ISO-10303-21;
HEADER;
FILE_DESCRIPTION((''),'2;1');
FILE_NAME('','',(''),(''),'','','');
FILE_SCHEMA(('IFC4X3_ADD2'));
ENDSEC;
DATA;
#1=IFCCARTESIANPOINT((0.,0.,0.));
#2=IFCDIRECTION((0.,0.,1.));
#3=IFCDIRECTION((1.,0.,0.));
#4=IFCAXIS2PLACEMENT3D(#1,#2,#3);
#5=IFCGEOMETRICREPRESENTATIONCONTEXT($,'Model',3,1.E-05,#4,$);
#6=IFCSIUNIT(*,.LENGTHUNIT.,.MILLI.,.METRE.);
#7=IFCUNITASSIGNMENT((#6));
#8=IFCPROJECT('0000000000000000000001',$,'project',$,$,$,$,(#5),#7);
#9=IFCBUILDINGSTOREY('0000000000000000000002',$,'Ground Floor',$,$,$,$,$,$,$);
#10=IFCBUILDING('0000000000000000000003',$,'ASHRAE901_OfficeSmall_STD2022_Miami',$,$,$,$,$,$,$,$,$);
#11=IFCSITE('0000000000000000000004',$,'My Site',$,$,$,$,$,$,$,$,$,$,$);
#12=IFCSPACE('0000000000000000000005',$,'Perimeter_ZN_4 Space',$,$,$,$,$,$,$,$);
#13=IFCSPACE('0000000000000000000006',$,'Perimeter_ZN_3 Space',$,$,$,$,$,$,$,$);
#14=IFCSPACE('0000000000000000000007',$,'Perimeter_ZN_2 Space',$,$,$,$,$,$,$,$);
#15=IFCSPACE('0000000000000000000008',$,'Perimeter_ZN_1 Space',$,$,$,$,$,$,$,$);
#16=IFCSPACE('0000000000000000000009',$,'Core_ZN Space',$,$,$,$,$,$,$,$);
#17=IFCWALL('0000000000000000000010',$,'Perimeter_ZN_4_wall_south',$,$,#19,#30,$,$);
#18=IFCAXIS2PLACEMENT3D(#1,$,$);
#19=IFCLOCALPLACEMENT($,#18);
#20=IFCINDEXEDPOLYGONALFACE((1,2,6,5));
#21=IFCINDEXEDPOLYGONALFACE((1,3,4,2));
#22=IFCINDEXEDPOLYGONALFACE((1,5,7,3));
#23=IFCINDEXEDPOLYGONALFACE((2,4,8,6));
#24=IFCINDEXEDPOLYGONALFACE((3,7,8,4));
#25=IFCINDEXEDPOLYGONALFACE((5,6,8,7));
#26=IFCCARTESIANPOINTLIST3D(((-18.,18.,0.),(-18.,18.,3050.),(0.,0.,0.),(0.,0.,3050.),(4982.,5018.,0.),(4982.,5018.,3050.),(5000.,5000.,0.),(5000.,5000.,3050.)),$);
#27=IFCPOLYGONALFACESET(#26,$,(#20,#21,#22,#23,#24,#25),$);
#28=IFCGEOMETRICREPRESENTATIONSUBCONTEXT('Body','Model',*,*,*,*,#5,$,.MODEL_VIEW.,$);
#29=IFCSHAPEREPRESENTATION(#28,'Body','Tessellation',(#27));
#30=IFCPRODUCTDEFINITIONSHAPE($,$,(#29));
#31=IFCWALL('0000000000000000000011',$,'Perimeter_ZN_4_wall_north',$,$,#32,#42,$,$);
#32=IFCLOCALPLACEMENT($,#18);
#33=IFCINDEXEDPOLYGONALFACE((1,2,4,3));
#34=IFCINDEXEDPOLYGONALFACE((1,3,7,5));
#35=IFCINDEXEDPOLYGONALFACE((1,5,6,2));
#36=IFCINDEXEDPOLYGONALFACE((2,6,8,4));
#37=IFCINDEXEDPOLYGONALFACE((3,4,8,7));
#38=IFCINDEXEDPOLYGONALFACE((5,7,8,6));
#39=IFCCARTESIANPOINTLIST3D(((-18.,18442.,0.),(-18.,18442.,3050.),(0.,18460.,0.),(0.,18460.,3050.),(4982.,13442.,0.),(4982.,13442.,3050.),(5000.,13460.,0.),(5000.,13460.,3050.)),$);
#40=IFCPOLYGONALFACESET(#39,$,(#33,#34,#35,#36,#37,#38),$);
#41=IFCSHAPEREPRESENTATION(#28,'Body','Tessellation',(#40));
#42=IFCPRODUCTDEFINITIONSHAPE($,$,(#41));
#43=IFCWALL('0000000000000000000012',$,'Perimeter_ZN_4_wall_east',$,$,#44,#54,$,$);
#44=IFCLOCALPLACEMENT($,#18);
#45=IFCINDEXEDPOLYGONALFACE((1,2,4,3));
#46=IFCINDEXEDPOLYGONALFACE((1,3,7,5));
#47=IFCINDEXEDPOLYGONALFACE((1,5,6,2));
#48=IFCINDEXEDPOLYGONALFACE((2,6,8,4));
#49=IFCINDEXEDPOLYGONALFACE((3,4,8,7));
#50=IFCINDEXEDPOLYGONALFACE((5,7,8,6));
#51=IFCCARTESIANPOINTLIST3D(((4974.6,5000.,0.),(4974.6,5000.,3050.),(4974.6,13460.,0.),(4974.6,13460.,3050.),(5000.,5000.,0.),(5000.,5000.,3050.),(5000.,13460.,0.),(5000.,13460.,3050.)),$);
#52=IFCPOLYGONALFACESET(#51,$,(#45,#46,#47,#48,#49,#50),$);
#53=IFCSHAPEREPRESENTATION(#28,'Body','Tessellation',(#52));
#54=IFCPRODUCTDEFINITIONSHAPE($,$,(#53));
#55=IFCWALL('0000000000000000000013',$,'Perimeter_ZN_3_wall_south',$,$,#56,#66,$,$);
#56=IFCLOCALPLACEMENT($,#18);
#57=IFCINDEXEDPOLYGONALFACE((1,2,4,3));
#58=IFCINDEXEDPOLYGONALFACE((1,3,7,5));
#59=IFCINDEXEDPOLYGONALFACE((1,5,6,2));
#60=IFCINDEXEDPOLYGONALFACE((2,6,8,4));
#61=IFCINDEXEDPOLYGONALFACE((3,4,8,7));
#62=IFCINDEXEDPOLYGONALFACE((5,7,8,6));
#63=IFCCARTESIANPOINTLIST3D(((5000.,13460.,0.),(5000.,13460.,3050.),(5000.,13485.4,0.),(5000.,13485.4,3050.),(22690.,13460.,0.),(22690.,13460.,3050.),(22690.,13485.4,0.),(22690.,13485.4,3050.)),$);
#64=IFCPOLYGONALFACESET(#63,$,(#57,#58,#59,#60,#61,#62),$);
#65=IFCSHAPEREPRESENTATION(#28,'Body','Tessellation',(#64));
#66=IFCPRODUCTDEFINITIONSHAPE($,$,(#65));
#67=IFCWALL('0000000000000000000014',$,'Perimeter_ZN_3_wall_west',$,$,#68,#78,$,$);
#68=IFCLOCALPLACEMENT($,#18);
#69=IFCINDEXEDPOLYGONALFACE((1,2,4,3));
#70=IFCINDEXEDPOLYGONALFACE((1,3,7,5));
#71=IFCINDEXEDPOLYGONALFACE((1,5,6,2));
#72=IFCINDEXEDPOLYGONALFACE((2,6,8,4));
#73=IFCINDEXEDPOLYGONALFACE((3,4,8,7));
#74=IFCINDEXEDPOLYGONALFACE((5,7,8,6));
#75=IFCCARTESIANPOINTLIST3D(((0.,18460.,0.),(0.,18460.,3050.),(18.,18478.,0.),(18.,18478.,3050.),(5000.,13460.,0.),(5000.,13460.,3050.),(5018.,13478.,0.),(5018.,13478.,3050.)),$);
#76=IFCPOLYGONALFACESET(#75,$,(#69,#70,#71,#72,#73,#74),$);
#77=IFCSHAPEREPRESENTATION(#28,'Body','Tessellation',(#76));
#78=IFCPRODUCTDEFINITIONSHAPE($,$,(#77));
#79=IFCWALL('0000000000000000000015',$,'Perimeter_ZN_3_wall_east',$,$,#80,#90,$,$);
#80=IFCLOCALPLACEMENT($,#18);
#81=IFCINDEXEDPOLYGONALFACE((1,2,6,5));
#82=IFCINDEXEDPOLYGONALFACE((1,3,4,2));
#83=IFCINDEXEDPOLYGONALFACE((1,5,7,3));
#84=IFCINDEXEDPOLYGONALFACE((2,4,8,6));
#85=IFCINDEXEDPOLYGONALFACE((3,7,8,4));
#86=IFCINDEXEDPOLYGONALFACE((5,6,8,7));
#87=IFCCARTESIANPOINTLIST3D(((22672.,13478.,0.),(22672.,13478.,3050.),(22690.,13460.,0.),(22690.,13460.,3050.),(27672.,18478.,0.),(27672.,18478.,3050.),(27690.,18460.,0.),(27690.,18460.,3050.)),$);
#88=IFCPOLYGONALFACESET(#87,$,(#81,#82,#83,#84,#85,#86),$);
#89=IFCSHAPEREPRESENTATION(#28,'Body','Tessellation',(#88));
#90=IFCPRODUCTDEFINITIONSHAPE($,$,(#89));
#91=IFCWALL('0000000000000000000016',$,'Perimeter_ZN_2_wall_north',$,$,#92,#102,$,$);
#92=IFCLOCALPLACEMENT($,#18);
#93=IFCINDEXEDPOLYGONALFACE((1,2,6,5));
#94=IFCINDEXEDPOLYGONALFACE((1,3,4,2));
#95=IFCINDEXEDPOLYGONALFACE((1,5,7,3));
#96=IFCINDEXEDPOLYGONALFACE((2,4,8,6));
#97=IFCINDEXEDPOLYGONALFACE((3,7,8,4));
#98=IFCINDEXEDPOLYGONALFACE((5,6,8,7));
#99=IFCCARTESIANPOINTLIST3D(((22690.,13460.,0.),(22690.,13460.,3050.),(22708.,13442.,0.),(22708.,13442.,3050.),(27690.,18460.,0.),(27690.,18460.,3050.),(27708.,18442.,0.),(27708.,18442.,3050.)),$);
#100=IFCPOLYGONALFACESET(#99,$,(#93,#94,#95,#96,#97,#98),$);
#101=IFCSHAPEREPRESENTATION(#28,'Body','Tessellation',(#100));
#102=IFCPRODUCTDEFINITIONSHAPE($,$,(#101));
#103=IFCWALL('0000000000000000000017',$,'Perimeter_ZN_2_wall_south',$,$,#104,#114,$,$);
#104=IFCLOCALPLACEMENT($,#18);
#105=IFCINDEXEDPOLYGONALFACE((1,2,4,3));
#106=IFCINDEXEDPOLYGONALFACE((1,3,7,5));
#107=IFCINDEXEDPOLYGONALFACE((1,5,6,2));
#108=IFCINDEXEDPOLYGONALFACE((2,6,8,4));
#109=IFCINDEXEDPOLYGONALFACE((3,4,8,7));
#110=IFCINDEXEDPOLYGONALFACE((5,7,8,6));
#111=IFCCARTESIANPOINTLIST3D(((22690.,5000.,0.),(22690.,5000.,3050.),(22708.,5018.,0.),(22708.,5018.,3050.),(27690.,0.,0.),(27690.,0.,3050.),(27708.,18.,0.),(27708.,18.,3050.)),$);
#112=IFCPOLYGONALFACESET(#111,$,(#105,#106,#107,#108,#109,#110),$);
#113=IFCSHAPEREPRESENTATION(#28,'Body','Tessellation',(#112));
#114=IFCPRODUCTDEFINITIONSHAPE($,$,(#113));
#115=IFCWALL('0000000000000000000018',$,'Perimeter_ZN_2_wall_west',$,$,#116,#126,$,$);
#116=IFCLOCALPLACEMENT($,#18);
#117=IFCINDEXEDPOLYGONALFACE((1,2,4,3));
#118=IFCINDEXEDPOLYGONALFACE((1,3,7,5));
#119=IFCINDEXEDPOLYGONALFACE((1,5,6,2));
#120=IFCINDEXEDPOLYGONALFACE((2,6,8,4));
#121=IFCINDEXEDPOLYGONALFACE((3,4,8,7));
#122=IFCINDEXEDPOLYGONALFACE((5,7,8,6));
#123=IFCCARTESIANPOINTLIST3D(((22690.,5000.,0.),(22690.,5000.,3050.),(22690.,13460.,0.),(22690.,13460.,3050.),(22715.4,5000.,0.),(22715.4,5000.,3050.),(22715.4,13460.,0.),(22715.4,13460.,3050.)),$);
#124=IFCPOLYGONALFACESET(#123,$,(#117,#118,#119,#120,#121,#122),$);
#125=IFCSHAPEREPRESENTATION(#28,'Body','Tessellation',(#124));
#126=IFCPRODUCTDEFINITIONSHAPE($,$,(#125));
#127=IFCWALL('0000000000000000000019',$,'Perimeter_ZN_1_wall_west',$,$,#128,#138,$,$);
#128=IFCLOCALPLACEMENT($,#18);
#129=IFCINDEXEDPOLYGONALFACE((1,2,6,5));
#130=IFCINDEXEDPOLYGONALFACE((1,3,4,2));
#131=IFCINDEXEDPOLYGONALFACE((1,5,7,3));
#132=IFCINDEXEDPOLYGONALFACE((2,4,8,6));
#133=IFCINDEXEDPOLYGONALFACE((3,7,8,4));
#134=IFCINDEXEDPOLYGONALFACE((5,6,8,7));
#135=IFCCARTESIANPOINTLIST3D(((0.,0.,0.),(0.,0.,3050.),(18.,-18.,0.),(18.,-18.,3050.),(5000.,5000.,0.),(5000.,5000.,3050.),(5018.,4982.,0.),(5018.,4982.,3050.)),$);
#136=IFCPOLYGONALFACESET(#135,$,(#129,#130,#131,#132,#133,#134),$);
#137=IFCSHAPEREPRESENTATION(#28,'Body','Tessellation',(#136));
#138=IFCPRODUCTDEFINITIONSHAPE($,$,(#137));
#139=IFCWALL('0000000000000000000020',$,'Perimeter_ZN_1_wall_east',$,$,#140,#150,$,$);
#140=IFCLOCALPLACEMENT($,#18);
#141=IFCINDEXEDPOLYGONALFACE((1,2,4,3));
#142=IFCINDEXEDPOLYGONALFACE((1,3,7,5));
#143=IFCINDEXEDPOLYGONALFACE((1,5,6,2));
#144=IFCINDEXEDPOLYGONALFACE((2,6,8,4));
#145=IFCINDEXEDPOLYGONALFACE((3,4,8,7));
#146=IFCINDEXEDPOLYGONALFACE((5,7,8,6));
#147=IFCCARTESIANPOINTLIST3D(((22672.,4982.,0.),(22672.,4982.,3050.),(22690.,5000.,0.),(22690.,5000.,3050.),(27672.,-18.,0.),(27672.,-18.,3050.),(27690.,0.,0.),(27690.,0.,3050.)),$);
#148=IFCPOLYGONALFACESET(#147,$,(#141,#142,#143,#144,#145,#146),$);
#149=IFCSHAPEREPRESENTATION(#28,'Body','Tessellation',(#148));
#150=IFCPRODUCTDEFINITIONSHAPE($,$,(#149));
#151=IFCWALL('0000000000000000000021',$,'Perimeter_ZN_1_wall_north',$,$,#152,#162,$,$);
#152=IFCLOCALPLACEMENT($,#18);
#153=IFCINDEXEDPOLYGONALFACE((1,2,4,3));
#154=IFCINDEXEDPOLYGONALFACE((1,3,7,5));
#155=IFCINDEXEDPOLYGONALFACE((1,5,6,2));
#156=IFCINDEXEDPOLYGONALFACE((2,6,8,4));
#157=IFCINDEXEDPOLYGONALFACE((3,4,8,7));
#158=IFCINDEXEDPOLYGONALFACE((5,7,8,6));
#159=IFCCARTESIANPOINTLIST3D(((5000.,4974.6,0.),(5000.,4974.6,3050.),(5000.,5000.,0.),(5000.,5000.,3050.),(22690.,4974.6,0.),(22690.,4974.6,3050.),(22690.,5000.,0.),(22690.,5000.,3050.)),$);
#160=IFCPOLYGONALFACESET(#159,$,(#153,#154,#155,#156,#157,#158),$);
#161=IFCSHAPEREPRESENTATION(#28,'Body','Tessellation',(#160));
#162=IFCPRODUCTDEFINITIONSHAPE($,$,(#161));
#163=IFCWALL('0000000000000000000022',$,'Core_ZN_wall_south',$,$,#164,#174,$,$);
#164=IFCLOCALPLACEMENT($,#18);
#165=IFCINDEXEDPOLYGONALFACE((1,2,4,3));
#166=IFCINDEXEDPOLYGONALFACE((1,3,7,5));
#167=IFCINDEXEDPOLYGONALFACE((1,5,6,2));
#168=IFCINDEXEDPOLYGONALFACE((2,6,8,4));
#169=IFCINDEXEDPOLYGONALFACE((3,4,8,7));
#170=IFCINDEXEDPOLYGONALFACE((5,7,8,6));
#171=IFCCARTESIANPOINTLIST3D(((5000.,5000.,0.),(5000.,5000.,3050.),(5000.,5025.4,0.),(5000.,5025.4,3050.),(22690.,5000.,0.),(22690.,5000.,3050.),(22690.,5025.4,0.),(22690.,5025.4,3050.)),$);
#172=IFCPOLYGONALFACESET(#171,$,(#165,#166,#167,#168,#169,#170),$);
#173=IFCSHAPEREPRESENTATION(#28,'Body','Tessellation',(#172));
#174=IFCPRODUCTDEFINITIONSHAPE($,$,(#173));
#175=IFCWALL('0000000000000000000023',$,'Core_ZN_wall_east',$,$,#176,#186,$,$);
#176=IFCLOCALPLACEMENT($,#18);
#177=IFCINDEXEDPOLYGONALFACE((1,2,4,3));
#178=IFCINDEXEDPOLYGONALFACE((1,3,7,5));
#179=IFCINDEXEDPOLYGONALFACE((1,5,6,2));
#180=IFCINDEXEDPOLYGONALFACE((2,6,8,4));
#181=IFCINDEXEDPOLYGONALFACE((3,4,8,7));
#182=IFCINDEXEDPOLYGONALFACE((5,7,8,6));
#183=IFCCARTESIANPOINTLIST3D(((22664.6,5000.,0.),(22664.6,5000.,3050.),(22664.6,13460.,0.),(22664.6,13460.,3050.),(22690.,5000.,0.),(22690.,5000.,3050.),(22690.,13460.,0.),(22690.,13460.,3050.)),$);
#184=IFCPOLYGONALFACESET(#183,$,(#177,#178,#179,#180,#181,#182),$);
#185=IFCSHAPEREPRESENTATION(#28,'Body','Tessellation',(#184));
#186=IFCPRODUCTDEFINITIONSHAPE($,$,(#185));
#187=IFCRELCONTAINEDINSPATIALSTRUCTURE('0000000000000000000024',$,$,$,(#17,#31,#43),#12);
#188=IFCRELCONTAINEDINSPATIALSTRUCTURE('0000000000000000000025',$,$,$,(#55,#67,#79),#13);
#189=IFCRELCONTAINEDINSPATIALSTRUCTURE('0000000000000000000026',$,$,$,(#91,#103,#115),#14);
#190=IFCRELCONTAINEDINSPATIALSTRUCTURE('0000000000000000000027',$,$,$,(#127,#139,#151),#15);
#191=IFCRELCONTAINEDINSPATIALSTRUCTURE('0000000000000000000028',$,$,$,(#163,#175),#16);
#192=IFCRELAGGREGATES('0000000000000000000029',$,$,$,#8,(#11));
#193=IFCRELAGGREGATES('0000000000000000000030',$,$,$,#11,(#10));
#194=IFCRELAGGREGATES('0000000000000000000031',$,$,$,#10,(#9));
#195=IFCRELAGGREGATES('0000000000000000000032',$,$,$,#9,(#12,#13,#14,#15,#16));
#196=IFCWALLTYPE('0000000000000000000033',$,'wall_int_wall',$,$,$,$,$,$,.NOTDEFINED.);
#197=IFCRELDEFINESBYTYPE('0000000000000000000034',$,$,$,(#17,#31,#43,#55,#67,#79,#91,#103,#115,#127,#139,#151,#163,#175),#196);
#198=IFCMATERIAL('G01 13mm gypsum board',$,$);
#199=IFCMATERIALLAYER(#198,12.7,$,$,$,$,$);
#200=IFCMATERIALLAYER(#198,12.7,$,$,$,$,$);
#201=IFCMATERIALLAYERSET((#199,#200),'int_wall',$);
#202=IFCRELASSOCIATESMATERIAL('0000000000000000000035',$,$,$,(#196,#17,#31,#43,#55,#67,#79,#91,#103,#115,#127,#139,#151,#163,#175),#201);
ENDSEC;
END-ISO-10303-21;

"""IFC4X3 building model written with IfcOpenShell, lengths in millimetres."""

from ifc_helpers import new_model, si_unit, frame, origin_with_axes, place, context, subcontext, project, spatial, indexed_curve, outline, extrude, material, layer, layer_set, layer_usage, type_object, element, save


model = new_model("IFC4X3")

# Units and contexts
model_context = context("Model", 3, precision=1e-05, world=origin_with_axes())
body_context = subcontext(model_context, "Body", "Model", "MODEL_VIEW")
ifc_project = project(units=[si_unit("LENGTHUNIT", "METRE", prefix="MILLI")], contexts=[model_context])

# Site, building, storey, space
site = spatial("IfcSite", under=ifc_project, Name="My Site")
building = spatial("IfcBuilding", under=site, Name="ASHRAE901_OfficeSmall_STD2022_Miami")
storey = spatial("IfcBuildingStorey", under=building, Name="Ground Floor")
space_1 = spatial("IfcSpace", under=storey, Name="Perimeter_ZN_4 Space")

# Walls
ifc_material = material(Name="G01 13mm gypsum board")
ifc_layer_1 = layer(ifc_material, 12.7)
ifc_layer_2 = layer(ifc_material, 12.7)
ifc_layer_set = layer_set([ifc_layer_1, ifc_layer_2], Name="int_wall")
ifc_layer_usage_1 = layer_usage(ifc_layer_set, "AXIS2", "POSITIVE", 0.0)
wall_type = type_object("IfcWallType", Name="wall_int_wall", PredefinedType="NOTDEFINED", material=ifc_layer_set)
wall_1_placement = place(None, frame((0.0, 0.0, 0.0), z_axis=(0.0, 0.0, 1.0), x_axis=(0.707107, 0.707107, 0.0)))
element("IfcWall", 1, at=wall_1_placement, inside=space_1, type_object=wall_type, material=ifc_layer_usage_1, Name="Perimeter_ZN_4_wall_south", context=body_context, shape_type="SweptSolid", body=[
    extrude(outline(indexed_curve([(0.0, 0.0), (0.0, 25.4), (7071.1, 25.4), (7071.1, 0.0), (0.0, 0.0)], self_intersect=False)), origin_with_axes(), (0.0, 0.0, 1.0), 3050.0),
])
ifc_layer_usage_2 = layer_usage(ifc_layer_set, "AXIS2", "POSITIVE", 0.0)
wall_2_placement = place(None, frame((5000.0, 13460.0, 0.0), z_axis=(0.0, 0.0, 1.0), x_axis=(-0.707107, 0.707107, 0.0)))
element("IfcWall", 2, at=wall_2_placement, inside=space_1, type_object=wall_type, material=ifc_layer_usage_2, Name="Perimeter_ZN_4_wall_north", context=body_context, shape_type="SweptSolid", body=[
    extrude(outline(indexed_curve([(0.0, 0.0), (0.0, 25.4), (7071.1, 25.4), (7071.1, 0.0), (0.0, 0.0)], self_intersect=False)), origin_with_axes(), (0.0, 0.0, 1.0), 3050.0),
])
ifc_layer_usage_3 = layer_usage(ifc_layer_set, "AXIS2", "POSITIVE", 0.0)
wall_3_placement = place(None, frame((5000.0, 5000.0, 0.0), z_axis=(0.0, 0.0, 1.0), x_axis=(0.0, 1.0, 0.0)))
element("IfcWall", 3, at=wall_3_placement, inside=space_1, type_object=wall_type, material=ifc_layer_usage_3, Name="Perimeter_ZN_4_wall_east", context=body_context, shape_type="SweptSolid", body=[
    extrude(outline(indexed_curve([(0.0, 0.0), (0.0, 25.4), (8460.0, 25.4), (8460.0, 0.0), (0.0, 0.0)], self_intersect=False)), origin_with_axes(), (0.0, 0.0, 1.0), 3050.0),
])

# Shared definitions
space_2 = spatial("IfcSpace", under=storey, Name="Perimeter_ZN_3 Space")

# Walls
ifc_layer_usage_4 = layer_usage(ifc_layer_set, "AXIS2", "POSITIVE", 0.0)
wall_4_placement = place(None, frame((5000.0, 13460.0, 0.0), z_axis=(0.0, 0.0, 1.0), x_axis=(1.0, 0.0, 0.0)))
element("IfcWall", 4, at=wall_4_placement, inside=space_2, type_object=wall_type, material=ifc_layer_usage_4, Name="Perimeter_ZN_3_wall_south", context=body_context, shape_type="SweptSolid", body=[
    extrude(outline(indexed_curve([(0.0, 0.0), (0.0, 25.4), (17690.0, 25.4), (17690.0, 0.0), (0.0, 0.0)], self_intersect=False)), origin_with_axes(), (0.0, 0.0, 1.0), 3050.0),
])
ifc_layer_usage_5 = layer_usage(ifc_layer_set, "AXIS2", "POSITIVE", 0.0)
wall_5_placement = place(None, frame((0.0, 18460.0, 0.0), z_axis=(0.0, 0.0, 1.0), x_axis=(0.707107, -0.707107, 0.0)))
element("IfcWall", 5, at=wall_5_placement, inside=space_2, type_object=wall_type, material=ifc_layer_usage_5, Name="Perimeter_ZN_3_wall_west", context=body_context, shape_type="SweptSolid", body=[
    extrude(outline(indexed_curve([(0.0, 0.0), (0.0, 25.4), (7071.1, 25.4), (7071.1, 0.0), (0.0, 0.0)], self_intersect=False)), origin_with_axes(), (0.0, 0.0, 1.0), 3050.0),
])
ifc_layer_usage_6 = layer_usage(ifc_layer_set, "AXIS2", "POSITIVE", 0.0)
wall_6_placement = place(None, frame((22690.0, 13460.0, 0.0), z_axis=(0.0, 0.0, 1.0), x_axis=(0.707107, 0.707107, 0.0)))
element("IfcWall", 6, at=wall_6_placement, inside=space_2, type_object=wall_type, material=ifc_layer_usage_6, Name="Perimeter_ZN_3_wall_east", context=body_context, shape_type="SweptSolid", body=[
    extrude(outline(indexed_curve([(0.0, 0.0), (0.0, 25.4), (7071.1, 25.4), (7071.1, 0.0), (0.0, 0.0)], self_intersect=False)), origin_with_axes(), (0.0, 0.0, 1.0), 3050.0),
])

# Shared definitions
space_3 = spatial("IfcSpace", under=storey, Name="Perimeter_ZN_2 Space")

# Walls
ifc_layer_usage_7 = layer_usage(ifc_layer_set, "AXIS2", "POSITIVE", 0.0)
wall_7_placement = place(None, frame((27690.0, 18460.0, 0.0), z_axis=(0.0, 0.0, 1.0), x_axis=(-0.707107, -0.707107, 0.0)))
element("IfcWall", 7, at=wall_7_placement, inside=space_3, type_object=wall_type, material=ifc_layer_usage_7, Name="Perimeter_ZN_2_wall_north", context=body_context, shape_type="SweptSolid", body=[
    extrude(outline(indexed_curve([(0.0, 0.0), (0.0, 25.4), (7071.1, 25.4), (7071.1, 0.0), (0.0, 0.0)], self_intersect=False)), origin_with_axes(), (0.0, 0.0, 1.0), 3050.0),
])
ifc_layer_usage_8 = layer_usage(ifc_layer_set, "AXIS2", "POSITIVE", 0.0)
wall_8_placement = place(None, frame((22690.0, 5000.0, 0.0), z_axis=(0.0, 0.0, 1.0), x_axis=(0.707107, -0.707107, 0.0)))
element("IfcWall", 8, at=wall_8_placement, inside=space_3, type_object=wall_type, material=ifc_layer_usage_8, Name="Perimeter_ZN_2_wall_south", context=body_context, shape_type="SweptSolid", body=[
    extrude(outline(indexed_curve([(0.0, 0.0), (0.0, 25.4), (7071.1, 25.4), (7071.1, 0.0), (0.0, 0.0)], self_intersect=False)), origin_with_axes(), (0.0, 0.0, 1.0), 3050.0),
])
ifc_layer_usage_9 = layer_usage(ifc_layer_set, "AXIS2", "POSITIVE", 0.0)
wall_9_placement = place(None, frame((22690.0, 13460.0, 0.0), z_axis=(0.0, 0.0, 1.0), x_axis=(0.0, -1.0, 0.0)))
element("IfcWall", 9, at=wall_9_placement, inside=space_3, type_object=wall_type, material=ifc_layer_usage_9, Name="Perimeter_ZN_2_wall_west", context=body_context, shape_type="SweptSolid", body=[
    extrude(outline(indexed_curve([(0.0, 0.0), (0.0, 25.4), (8460.0, 25.4), (8460.0, 0.0), (0.0, 0.0)], self_intersect=False)), origin_with_axes(), (0.0, 0.0, 1.0), 3050.0),
])

# Shared definitions
space_4 = spatial("IfcSpace", under=storey, Name="Perimeter_ZN_1 Space")

# Walls
ifc_layer_usage_10 = layer_usage(ifc_layer_set, "AXIS2", "POSITIVE", 0.0)
wall_10_placement = place(None, frame((5000.0, 5000.0, 0.0), z_axis=(0.0, 0.0, 1.0), x_axis=(-0.707107, -0.707107, 0.0)))
element("IfcWall", 10, at=wall_10_placement, inside=space_4, type_object=wall_type, material=ifc_layer_usage_10, Name="Perimeter_ZN_1_wall_west", context=body_context, shape_type="SweptSolid", body=[
    extrude(outline(indexed_curve([(0.0, 0.0), (0.0, 25.4), (7071.1, 25.4), (7071.1, 0.0), (0.0, 0.0)], self_intersect=False)), origin_with_axes(), (0.0, 0.0, 1.0), 3050.0),
])
ifc_layer_usage_11 = layer_usage(ifc_layer_set, "AXIS2", "POSITIVE", 0.0)
wall_11_placement = place(None, frame((27690.0, 0.0, 0.0), z_axis=(0.0, 0.0, 1.0), x_axis=(-0.707107, 0.707107, 0.0)))
element("IfcWall", 11, at=wall_11_placement, inside=space_4, type_object=wall_type, material=ifc_layer_usage_11, Name="Perimeter_ZN_1_wall_east", context=body_context, shape_type="SweptSolid", body=[
    extrude(outline(indexed_curve([(0.0, 0.0), (0.0, 25.4), (7071.1, 25.4), (7071.1, 0.0), (0.0, 0.0)], self_intersect=False)), origin_with_axes(), (0.0, 0.0, 1.0), 3050.0),
])
ifc_layer_usage_12 = layer_usage(ifc_layer_set, "AXIS2", "POSITIVE", 0.0)
wall_12_placement = place(None, frame((22690.0, 5000.0, 0.0), z_axis=(0.0, 0.0, 1.0), x_axis=(-1.0, 0.0, 0.0)))
element("IfcWall", 12, at=wall_12_placement, inside=space_4, type_object=wall_type, material=ifc_layer_usage_12, Name="Perimeter_ZN_1_wall_north", context=body_context, shape_type="SweptSolid", body=[
    extrude(outline(indexed_curve([(0.0, 0.0), (0.0, 25.4), (17690.0, 25.4), (17690.0, 0.0), (0.0, 0.0)], self_intersect=False)), origin_with_axes(), (0.0, 0.0, 1.0), 3050.0),
])

# Shared definitions
space_5 = spatial("IfcSpace", under=storey, Name="Core_ZN Space")

# Walls
ifc_layer_usage_13 = layer_usage(ifc_layer_set, "AXIS2", "POSITIVE", 0.0)
wall_13_placement = place(None, frame((5000.0, 5000.0, 0.0), z_axis=(0.0, 0.0, 1.0), x_axis=(1.0, 0.0, 0.0)))
element("IfcWall", 13, at=wall_13_placement, inside=space_5, type_object=wall_type, material=ifc_layer_usage_13, Name="Core_ZN_wall_south", context=body_context, shape_type="SweptSolid", body=[
    extrude(outline(indexed_curve([(0.0, 0.0), (0.0, 25.4), (17690.0, 25.4), (17690.0, 0.0), (0.0, 0.0)], self_intersect=False)), origin_with_axes(), (0.0, 0.0, 1.0), 3050.0),
])
ifc_layer_usage_14 = layer_usage(ifc_layer_set, "AXIS2", "POSITIVE", 0.0)
wall_14_placement = place(None, frame((22690.0, 5000.0, 0.0), z_axis=(0.0, 0.0, 1.0), x_axis=(0.0, 1.0, 0.0)))
element("IfcWall", 14, at=wall_14_placement, inside=space_5, type_object=wall_type, material=ifc_layer_usage_14, Name="Core_ZN_wall_east", context=body_context, shape_type="SweptSolid", body=[
    extrude(outline(indexed_curve([(0.0, 0.0), (0.0, 25.4), (8460.0, 25.4), (8460.0, 0.0), (0.0, 0.0)], self_intersect=False)), origin_with_axes(), (0.0, 0.0, 1.0), 3050.0),
])

save(model, "model.ifc")
